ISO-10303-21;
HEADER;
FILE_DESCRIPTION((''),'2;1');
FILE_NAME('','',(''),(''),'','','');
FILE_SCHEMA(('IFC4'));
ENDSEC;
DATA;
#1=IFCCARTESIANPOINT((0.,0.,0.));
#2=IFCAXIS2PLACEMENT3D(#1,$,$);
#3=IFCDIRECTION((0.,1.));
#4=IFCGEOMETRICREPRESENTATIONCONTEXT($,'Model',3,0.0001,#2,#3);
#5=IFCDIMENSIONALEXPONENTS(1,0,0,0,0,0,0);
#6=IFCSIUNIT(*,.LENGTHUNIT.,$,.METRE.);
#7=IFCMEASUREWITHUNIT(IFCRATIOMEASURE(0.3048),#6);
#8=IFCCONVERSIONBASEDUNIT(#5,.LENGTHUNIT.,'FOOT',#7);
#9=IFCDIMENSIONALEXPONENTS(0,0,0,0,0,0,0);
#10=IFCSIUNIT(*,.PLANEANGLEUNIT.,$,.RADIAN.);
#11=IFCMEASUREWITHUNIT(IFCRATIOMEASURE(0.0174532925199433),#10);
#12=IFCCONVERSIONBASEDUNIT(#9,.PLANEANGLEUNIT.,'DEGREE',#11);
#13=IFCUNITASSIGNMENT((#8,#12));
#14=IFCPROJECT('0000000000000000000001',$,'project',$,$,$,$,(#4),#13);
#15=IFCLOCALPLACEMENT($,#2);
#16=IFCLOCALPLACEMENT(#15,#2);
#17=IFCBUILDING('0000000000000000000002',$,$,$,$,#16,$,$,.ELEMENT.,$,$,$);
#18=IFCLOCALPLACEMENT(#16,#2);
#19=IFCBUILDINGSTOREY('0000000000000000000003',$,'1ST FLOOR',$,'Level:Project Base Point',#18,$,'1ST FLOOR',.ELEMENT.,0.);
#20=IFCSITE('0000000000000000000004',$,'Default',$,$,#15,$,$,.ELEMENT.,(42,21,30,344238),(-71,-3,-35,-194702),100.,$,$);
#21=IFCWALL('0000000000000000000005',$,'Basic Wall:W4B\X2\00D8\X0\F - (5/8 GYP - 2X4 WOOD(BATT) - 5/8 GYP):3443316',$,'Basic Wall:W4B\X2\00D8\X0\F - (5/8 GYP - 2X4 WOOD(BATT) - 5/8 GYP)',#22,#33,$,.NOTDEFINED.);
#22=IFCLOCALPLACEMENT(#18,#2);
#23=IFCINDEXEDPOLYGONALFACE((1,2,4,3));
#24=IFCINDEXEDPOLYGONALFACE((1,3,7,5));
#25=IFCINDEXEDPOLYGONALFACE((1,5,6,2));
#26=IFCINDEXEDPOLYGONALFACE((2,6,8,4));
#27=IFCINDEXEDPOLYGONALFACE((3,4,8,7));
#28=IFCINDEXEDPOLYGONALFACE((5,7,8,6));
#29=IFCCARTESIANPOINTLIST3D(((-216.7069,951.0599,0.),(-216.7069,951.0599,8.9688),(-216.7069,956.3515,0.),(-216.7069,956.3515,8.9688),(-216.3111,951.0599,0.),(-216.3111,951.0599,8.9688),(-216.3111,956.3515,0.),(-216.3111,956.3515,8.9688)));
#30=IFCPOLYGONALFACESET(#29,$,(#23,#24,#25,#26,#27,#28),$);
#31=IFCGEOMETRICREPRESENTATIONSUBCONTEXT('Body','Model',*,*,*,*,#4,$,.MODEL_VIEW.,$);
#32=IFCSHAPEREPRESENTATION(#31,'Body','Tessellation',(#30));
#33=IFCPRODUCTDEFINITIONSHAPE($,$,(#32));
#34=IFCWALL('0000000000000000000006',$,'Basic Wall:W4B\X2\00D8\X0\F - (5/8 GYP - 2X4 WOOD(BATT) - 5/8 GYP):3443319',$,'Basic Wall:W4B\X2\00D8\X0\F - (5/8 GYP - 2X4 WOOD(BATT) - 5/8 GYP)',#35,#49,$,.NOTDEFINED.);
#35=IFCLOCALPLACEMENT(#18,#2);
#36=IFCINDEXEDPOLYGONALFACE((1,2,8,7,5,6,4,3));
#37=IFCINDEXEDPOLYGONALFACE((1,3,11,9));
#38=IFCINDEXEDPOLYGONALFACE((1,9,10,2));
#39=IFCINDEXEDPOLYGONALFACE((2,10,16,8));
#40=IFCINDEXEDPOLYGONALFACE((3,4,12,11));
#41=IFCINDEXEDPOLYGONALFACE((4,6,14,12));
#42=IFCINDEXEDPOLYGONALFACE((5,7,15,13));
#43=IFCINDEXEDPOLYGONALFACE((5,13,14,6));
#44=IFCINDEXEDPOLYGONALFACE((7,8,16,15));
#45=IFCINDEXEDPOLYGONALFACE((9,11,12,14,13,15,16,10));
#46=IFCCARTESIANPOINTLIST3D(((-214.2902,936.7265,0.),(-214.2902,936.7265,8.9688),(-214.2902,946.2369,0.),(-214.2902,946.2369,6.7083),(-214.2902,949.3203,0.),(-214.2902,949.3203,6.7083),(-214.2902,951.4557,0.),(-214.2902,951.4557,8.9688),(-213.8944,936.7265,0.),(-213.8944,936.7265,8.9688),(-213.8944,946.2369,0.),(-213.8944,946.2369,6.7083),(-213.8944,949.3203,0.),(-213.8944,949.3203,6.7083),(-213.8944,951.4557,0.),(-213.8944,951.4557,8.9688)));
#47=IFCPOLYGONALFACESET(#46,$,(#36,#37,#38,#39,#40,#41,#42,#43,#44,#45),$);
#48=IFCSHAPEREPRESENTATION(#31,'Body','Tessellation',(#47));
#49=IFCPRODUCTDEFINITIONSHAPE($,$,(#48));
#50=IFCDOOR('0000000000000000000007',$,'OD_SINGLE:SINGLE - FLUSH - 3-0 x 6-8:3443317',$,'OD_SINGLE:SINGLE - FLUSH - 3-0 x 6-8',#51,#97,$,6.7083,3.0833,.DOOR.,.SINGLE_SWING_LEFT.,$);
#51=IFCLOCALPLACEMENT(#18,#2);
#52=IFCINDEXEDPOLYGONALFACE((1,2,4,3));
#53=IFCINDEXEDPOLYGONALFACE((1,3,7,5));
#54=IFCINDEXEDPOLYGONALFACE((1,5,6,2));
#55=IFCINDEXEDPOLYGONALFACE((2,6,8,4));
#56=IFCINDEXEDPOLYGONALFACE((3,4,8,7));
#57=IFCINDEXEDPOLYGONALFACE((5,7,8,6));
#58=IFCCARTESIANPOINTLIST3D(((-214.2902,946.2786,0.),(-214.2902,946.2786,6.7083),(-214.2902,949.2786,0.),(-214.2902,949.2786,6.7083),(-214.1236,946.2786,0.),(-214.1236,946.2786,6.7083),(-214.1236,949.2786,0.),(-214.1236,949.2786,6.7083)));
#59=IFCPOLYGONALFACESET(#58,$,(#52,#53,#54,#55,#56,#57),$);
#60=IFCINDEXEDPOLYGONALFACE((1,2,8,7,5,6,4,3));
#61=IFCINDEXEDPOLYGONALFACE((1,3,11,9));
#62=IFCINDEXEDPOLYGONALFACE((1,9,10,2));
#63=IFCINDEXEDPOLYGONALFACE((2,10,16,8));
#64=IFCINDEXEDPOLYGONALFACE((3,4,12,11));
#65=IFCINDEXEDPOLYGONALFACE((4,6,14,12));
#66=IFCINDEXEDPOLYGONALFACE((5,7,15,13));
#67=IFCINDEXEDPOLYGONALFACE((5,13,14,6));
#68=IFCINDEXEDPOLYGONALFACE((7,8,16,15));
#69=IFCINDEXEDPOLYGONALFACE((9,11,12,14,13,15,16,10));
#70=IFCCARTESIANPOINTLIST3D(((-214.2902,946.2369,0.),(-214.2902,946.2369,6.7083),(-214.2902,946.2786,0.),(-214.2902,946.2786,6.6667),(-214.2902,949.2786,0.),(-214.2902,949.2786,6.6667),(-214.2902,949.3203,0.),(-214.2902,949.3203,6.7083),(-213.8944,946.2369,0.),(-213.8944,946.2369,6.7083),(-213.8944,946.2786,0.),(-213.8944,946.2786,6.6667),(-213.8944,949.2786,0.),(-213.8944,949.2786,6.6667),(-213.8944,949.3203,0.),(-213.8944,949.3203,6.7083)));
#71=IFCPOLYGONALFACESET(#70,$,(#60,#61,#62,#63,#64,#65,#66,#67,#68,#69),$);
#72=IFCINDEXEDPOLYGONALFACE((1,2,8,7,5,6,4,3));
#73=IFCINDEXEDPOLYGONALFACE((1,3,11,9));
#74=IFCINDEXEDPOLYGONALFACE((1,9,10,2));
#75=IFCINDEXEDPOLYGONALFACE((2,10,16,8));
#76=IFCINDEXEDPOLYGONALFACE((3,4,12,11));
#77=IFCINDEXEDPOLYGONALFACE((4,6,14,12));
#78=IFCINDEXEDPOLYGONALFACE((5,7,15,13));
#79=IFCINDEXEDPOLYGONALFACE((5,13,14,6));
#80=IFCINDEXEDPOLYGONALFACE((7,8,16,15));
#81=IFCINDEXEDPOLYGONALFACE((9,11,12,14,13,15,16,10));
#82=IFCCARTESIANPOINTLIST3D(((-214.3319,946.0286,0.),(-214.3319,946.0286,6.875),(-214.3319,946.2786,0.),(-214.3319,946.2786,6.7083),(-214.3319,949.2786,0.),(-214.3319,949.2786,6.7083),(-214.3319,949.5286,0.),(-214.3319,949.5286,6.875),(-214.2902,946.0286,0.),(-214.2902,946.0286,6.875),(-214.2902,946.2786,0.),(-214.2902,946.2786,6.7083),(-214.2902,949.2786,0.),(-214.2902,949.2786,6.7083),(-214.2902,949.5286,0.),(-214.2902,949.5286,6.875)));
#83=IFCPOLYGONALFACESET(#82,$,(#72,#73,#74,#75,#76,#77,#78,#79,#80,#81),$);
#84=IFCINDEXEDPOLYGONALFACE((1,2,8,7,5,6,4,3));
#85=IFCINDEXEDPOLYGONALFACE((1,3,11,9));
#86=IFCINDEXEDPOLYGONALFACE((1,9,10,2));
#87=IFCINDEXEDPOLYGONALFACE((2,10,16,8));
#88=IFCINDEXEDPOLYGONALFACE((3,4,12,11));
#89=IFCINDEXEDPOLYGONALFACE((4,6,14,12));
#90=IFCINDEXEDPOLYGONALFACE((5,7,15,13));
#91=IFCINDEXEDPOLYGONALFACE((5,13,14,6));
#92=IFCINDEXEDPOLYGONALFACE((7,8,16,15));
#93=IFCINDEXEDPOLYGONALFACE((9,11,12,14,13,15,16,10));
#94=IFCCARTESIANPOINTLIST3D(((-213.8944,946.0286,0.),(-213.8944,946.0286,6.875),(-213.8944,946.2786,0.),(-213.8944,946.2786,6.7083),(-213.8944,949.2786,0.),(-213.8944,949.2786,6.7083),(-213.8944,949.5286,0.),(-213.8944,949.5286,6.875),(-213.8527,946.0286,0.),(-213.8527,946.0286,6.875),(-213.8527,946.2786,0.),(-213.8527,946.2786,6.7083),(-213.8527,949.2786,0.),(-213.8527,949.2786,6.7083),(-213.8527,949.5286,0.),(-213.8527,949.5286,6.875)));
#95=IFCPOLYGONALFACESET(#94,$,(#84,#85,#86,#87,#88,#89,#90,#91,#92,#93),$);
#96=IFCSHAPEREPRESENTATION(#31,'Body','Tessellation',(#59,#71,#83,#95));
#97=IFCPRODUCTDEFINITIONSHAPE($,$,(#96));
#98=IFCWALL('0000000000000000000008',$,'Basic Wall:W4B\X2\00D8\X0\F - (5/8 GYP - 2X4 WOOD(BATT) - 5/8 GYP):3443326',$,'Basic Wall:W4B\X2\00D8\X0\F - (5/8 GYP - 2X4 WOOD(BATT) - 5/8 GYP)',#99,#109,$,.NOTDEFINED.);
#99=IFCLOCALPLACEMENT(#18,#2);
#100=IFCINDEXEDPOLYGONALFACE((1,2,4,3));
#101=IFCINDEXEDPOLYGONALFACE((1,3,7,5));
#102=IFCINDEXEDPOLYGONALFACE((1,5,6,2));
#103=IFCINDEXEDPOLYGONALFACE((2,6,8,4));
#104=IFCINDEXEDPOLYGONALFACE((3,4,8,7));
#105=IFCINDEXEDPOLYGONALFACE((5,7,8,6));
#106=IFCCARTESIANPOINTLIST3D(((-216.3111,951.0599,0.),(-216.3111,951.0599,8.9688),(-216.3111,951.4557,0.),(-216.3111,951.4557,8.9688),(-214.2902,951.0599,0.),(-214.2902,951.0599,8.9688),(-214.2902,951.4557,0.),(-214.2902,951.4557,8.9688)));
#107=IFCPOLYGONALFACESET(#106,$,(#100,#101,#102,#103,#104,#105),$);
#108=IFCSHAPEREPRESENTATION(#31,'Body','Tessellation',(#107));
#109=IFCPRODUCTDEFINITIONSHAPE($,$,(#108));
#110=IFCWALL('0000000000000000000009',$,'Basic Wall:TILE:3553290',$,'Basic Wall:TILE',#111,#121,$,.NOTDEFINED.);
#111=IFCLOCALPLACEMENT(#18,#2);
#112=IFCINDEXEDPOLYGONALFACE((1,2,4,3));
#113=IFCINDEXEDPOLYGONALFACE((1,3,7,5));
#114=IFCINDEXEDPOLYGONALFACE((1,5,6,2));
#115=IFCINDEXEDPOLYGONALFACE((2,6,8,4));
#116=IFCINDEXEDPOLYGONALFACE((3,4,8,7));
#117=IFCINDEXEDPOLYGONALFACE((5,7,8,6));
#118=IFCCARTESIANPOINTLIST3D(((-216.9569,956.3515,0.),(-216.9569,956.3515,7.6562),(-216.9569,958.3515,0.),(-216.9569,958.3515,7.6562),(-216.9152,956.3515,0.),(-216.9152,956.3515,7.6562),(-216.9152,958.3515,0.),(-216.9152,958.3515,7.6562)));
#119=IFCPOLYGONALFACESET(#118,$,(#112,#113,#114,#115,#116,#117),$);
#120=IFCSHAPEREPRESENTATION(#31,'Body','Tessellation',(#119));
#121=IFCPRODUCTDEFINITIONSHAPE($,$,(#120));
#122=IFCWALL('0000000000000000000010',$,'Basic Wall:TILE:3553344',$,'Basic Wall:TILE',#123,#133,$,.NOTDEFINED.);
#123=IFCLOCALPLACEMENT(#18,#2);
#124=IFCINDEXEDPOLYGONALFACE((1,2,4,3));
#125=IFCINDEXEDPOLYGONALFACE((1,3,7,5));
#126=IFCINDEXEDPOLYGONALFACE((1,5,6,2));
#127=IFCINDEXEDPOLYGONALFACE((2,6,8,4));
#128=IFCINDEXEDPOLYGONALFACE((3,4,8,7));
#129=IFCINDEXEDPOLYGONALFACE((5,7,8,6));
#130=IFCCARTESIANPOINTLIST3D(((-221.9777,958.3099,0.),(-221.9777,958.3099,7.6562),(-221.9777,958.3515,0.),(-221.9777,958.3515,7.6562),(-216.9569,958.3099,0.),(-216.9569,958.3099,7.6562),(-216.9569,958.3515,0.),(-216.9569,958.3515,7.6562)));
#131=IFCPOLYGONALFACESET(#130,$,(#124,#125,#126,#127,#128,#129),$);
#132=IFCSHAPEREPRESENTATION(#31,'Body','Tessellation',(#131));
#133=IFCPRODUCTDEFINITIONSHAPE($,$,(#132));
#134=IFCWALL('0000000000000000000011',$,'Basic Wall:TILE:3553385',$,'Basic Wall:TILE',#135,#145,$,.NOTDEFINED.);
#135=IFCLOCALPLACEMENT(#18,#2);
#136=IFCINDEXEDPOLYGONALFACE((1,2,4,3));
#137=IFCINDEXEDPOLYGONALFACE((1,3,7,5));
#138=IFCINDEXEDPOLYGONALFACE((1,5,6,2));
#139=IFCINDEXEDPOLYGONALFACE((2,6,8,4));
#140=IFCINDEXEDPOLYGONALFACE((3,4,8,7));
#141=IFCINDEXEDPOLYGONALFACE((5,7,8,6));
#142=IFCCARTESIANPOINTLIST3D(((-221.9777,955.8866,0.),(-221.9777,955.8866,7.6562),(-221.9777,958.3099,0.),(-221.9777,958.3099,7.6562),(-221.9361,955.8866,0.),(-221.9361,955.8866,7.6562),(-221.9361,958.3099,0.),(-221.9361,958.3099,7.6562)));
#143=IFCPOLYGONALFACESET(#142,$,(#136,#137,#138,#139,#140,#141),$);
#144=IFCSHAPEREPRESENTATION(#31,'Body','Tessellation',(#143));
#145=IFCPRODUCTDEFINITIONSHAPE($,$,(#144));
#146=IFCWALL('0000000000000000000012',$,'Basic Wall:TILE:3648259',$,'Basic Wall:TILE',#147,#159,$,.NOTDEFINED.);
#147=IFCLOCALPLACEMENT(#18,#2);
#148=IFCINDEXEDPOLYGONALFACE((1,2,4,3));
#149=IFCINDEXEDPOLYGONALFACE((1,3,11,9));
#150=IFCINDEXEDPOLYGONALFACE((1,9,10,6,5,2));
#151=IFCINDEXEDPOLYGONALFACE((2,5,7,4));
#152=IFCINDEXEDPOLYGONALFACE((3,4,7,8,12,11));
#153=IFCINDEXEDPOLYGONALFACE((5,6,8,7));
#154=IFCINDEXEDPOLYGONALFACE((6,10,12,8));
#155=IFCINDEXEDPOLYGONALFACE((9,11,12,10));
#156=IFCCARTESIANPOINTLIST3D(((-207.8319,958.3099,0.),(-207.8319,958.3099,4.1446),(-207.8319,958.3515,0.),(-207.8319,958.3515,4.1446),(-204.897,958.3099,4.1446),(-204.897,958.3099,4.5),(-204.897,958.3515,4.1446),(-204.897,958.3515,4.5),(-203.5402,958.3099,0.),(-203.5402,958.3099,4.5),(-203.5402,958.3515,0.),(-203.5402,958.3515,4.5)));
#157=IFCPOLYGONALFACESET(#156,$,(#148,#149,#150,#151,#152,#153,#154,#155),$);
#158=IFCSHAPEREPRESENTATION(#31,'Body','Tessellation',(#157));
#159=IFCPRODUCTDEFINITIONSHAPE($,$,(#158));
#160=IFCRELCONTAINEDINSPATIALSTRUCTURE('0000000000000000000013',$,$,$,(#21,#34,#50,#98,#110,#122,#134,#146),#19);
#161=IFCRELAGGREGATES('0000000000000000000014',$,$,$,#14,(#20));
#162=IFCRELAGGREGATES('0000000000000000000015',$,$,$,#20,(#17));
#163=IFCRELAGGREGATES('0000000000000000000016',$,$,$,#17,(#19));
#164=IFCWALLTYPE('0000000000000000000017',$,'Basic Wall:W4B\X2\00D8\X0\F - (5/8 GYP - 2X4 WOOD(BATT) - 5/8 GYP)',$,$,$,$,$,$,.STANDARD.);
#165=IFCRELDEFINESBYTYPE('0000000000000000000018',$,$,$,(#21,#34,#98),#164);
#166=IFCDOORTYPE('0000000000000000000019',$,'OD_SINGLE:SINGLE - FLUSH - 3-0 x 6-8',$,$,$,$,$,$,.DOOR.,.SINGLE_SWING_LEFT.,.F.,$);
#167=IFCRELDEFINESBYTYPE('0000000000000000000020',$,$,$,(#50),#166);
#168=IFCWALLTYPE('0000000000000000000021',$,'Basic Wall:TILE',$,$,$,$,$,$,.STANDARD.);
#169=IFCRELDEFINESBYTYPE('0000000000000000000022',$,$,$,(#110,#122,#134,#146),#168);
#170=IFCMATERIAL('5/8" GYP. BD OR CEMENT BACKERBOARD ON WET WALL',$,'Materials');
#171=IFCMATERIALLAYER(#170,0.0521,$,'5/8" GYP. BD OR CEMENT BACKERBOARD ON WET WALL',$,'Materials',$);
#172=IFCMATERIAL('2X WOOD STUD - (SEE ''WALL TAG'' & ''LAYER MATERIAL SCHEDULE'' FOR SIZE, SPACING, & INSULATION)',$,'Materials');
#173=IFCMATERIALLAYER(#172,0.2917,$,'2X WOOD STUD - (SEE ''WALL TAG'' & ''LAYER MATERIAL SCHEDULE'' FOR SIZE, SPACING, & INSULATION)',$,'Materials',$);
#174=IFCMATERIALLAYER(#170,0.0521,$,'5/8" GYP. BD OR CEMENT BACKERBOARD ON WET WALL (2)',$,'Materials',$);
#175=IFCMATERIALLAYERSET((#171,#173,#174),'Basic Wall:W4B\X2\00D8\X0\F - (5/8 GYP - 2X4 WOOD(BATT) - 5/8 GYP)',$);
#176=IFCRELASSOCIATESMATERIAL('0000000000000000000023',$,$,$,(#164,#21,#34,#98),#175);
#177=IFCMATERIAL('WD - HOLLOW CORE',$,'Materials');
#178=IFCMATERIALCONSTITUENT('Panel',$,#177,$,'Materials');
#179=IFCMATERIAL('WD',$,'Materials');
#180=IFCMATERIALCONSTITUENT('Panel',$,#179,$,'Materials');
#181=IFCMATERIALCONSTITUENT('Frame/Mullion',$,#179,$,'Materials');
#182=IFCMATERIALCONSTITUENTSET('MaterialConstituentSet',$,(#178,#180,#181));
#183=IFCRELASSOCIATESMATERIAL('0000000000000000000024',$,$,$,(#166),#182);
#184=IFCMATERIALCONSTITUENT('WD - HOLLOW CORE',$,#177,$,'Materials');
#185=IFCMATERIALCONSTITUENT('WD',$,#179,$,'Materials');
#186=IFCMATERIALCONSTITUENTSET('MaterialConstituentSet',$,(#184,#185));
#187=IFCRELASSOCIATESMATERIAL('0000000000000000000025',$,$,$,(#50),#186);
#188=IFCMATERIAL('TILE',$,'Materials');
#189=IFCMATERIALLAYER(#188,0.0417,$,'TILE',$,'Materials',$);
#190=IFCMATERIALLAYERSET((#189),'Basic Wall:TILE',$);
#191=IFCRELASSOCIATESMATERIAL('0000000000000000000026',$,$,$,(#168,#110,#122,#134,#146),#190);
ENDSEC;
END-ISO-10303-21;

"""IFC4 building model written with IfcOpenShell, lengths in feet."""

from ifc_helpers import new_model, entity, si_unit, converted_unit, direction, frame, frame_2d, origin, origin_2d_with_axis, place, context, subcontext, project, spatial, polyline, rectangle, outline, extrude, source, transform, mapped, material, layer, layer_set, layer_usage, constituent, constituent_set, type_object, type_shapes, element, fill, save


model = new_model("IFC4")

# Units and contexts
model_context = context("Model", 3, precision=0.0001, world=origin(), true_north=direction((0.0, 1.0)))
body_context = subcontext(model_context, "Body", "Model", "MODEL_VIEW")
ifc_project = project(units=[converted_unit("LENGTHUNIT", "FOOT", entity("IfcRatioMeasure", 0.3048), si_unit("LENGTHUNIT", "METRE"), dimensions=[1, 0, 0, 0, 0, 0, 0]), converted_unit("PLANEANGLEUNIT", "DEGREE", entity("IfcRatioMeasure", 0.0174532925199433), si_unit("PLANEANGLEUNIT", "RADIAN"), dimensions=[0, 0, 0, 0, 0, 0, 0])], contexts=[model_context])

# Site, building, storey
site_placement = place(None, origin())
site = spatial("IfcSite", under=ifc_project, at=site_placement, Name="Default", CompositionType="ELEMENT", RefLatitude=(42, 21, 30, 344238), RefLongitude=(-71, -3, -35, -194702), RefElevation=100.0)
building_placement = place(site_placement, origin())
building = spatial("IfcBuilding", under=site, at=building_placement, CompositionType="ELEMENT")
storey_placement = place(building_placement, origin())
storey = spatial("IfcBuildingStorey", under=building, at=storey_placement, Name="1ST FLOOR", ObjectType="Level:Project Base Point", LongName="1ST FLOOR", CompositionType="ELEMENT", Elevation=0.0)

# Shared definitions
ifc_material_1 = material(Name="5/8\" GYP. BD OR CEMENT BACKERBOARD ON WET WALL", Category="Materials")
ifc_layer_1 = layer(ifc_material_1, 0.0521, Name="5/8\" GYP. BD OR CEMENT BACKERBOARD ON WET WALL", Category="Materials")
ifc_material_2 = material(Name="2X WOOD STUD - (SEE 'WALL TAG' & 'LAYER MATERIAL SCHEDULE' FOR SIZE, SPACING, & INSULATION)", Category="Materials")
ifc_layer_2 = layer(ifc_material_2, 0.2917, Name="2X WOOD STUD - (SEE 'WALL TAG' & 'LAYER MATERIAL SCHEDULE' FOR SIZE, SPACING, & INSULATION)", Category="Materials")
ifc_layer_3 = layer(ifc_material_1, 0.0521, Name="5/8\" GYP. BD OR CEMENT BACKERBOARD ON WET WALL (2)", Category="Materials")
ifc_layer_set_1 = layer_set([ifc_layer_1, ifc_layer_2, ifc_layer_3], Name="Basic Wall:W4BØF - (5/8 GYP - 2X4 WOOD(BATT) - 5/8 GYP)")
wall_type_1 = type_object("IfcWallType", Name="Basic Wall:W4BØF - (5/8 GYP - 2X4 WOOD(BATT) - 5/8 GYP)", PredefinedType="STANDARD", material=ifc_layer_set_1)
ifc_material_3 = material(Name="WD - HOLLOW CORE", Category="Materials")
ifc_material_4 = material(Name="WD", Category="Materials")

# Wall
ifc_layer_usage_1 = layer_usage(ifc_layer_set_1, "AXIS2", "POSITIVE", -0.1979)
wall_1_placement = place(storey_placement, frame((-216.509, 951.0599, 0.0), z_axis=(0.0, 0.0, 1.0), x_axis=(0.0, 1.0, 0.0)))
element("IfcWall", 1, at=wall_1_placement, inside=storey, type_object=wall_type_1, material=ifc_layer_usage_1, Name="Basic Wall:W4BØF - (5/8 GYP - 2X4 WOOD(BATT) - 5/8 GYP):3443316", ObjectType="Basic Wall:W4BØF - (5/8 GYP - 2X4 WOOD(BATT) - 5/8 GYP)", PredefinedType="NOTDEFINED", context=body_context, shape_type="SweptSolid", body=[
    extrude(rectangle(XDim=5.2917, YDim=0.3958, at=frame_2d((2.6458, 0.0), x_axis=(-1.0, 0.0))), origin(), (0.0, 0.0, 1.0), 8.9688),
])

# Wall, opening, door
ifc_layer_usage_2 = layer_usage(ifc_layer_set_1, "AXIS2", "POSITIVE", -0.1979)
wall_2_placement = place(storey_placement, frame((-214.0923, 936.7265, 0.0), z_axis=(0.0, 0.0, 1.0), x_axis=(0.0, 1.0, 0.0)))
wall_2 = element("IfcWall", 2, at=wall_2_placement, inside=storey, type_object=wall_type_1, material=ifc_layer_usage_2, Name="Basic Wall:W4BØF - (5/8 GYP - 2X4 WOOD(BATT) - 5/8 GYP):3443319", ObjectType="Basic Wall:W4BØF - (5/8 GYP - 2X4 WOOD(BATT) - 5/8 GYP)", PredefinedType="NOTDEFINED", context=body_context, shape_type="SweptSolid", body=[
    extrude(rectangle(XDim=14.7292, YDim=0.3958, at=frame_2d((7.3646, 0.0), x_axis=(-1.0, 0.0))), origin(), (0.0, 0.0, 1.0), 8.9688),
])
opening_1_placement = place(wall_2_placement, frame((9.5104, -0.1979, 0.0)))
opening_1 = element("IfcOpeningElement", 3, at=opening_1_placement, cuts=wall_2, PredefinedType="OPENING", context=body_context, shape_type="SweptSolid", body=[
    extrude(rectangle(XDim=3.0833, YDim=6.7083, at=frame_2d((3.3542, 1.5417), x_axis=(0.0, -1.0))), frame((0.0, 0.0, 0.0), z_axis=(0.0, 1.0, 0.0), x_axis=(0.0, 0.0, 1.0)), (0.0, 0.0, 1.0), 0.3958),
])
ifc_constituent_1 = constituent(ifc_material_3, Name="WD - HOLLOW CORE", Category="Materials")
ifc_constituent_2 = constituent(ifc_material_4, Name="WD", Category="Materials")
ifc_constituent_set_1 = constituent_set(constituents=[ifc_constituent_1, ifc_constituent_2], Name="MaterialConstituentSet")
ifc_constituent_3 = constituent(ifc_material_3, Name="Panel", Category="Materials")
ifc_constituent_4 = constituent(ifc_material_4, Name="Panel", Category="Materials")
ifc_constituent_5 = constituent(ifc_material_4, Name="Frame/Mullion", Category="Materials")
ifc_constituent_set_2 = constituent_set(constituents=[ifc_constituent_3, ifc_constituent_4, ifc_constituent_5], Name="MaterialConstituentSet")
door_type_1 = type_object("IfcDoorType", Name="OD_SINGLE:SINGLE - FLUSH - 3-0 x 6-8", OperationType="SINGLE_SWING_LEFT", ParameterTakesPrecedence=False, PredefinedType="DOOR", material=ifc_constituent_set_2)
shared_shape_1 = source(origin(), body_context, "Body", "SweptSolid", [
    extrude(rectangle(XDim=3.0, YDim=0.1667, at=origin_2d_with_axis()), frame((1.5417, 0.3125, 0.0)), (0.0, 0.0, 1.0), 6.7083),
    extrude(outline(polyline([(-3.3646, -1.5417), (3.3438, -1.5417), (3.3438, -1.5), (-3.3229, -1.5), (-3.3229, 1.5), (3.3438, 1.5), (3.3438, 1.5417), (-3.3646, 1.5417), (-3.3646, -1.5417)])), frame((1.5417, 0.3958, 3.3438), z_axis=(0.0, -1.0, 0.0), x_axis=(0.0, 0.0, -1.0)), (0.0, 0.0, 1.0), 0.3958),
    extrude(outline(polyline([(-1.75, -3.4792), (1.75, -3.4792), (1.75, 3.3958), (1.5, 3.3958), (1.5, -3.3125), (-1.5, -3.3125), (-1.5, 3.3958), (-1.75, 3.3958), (-1.75, -3.4792)])), frame((1.5417, 0.4375, 3.3958), z_axis=(0.0, -1.0, 0.0), x_axis=(-1.0, 0.0, 0.0)), (0.0, 0.0, 1.0), 0.0417),
    extrude(outline(polyline([(-3.4792, -1.75), (3.3958, -1.75), (3.3958, -1.5), (-3.3125, -1.5), (-3.3125, 1.5), (3.3958, 1.5), (3.3958, 1.75), (-3.4792, 1.75), (-3.4792, -1.75)])), frame((1.5417, 0.0, 3.3958), z_axis=(0.0, -1.0, 0.0), x_axis=(0.0, 0.0, -1.0)), (0.0, 0.0, 1.0), 0.0417),
])
type_shapes(door_type_1, [shared_shape_1])
door_1_placement = place(opening_1_placement, origin())
door_1 = element("IfcDoor", 4, at=door_1_placement, inside=storey, type_object=door_type_1, material=ifc_constituent_set_1, Name="OD_SINGLE:SINGLE - FLUSH - 3-0 x 6-8:3443317", ObjectType="OD_SINGLE:SINGLE - FLUSH - 3-0 x 6-8", OperationType="SINGLE_SWING_LEFT", OverallHeight=6.7083, OverallWidth=3.0833, PredefinedType="DOOR", context=body_context, shape_type="MappedRepresentation", body=[
    mapped(shared_shape_1, transform((0.0, 0.0, 0.0), scale=1.0)),
])
fill(opening_1, door_1)

# Wall
ifc_layer_usage_3 = layer_usage(ifc_layer_set_1, "AXIS2", "NEGATIVE", 0.1979)
wall_3_placement = place(storey_placement, frame((-216.3111, 951.2578, 0.0)))
element("IfcWall", 5, at=wall_3_placement, inside=storey, type_object=wall_type_1, material=ifc_layer_usage_3, Name="Basic Wall:W4BØF - (5/8 GYP - 2X4 WOOD(BATT) - 5/8 GYP):3443326", ObjectType="Basic Wall:W4BØF - (5/8 GYP - 2X4 WOOD(BATT) - 5/8 GYP)", PredefinedType="NOTDEFINED", context=body_context, shape_type="SweptSolid", body=[
    extrude(rectangle(XDim=2.0208, YDim=0.3958, at=frame_2d((1.0104, 0.0), x_axis=(-1.0, 0.0))), origin(), (0.0, 0.0, 1.0), 8.9688),
])

# Shared definitions
ifc_material_5 = material(Name="TILE", Category="Materials")
ifc_layer_4 = layer(ifc_material_5, 0.0417, Name="TILE", Category="Materials")
ifc_layer_set_2 = layer_set([ifc_layer_4], Name="Basic Wall:TILE")
wall_type_2 = type_object("IfcWallType", Name="Basic Wall:TILE", PredefinedType="STANDARD", material=ifc_layer_set_2)

# Walls
ifc_layer_usage_4 = layer_usage(ifc_layer_set_2, "AXIS2", "NEGATIVE", 0.0208)
wall_4_placement = place(storey_placement, frame((-216.9361, 956.3515, 0.0), z_axis=(0.0, 0.0, 1.0), x_axis=(0.0, 1.0, 0.0)))
element("IfcWall", 6, at=wall_4_placement, inside=storey, type_object=wall_type_2, material=ifc_layer_usage_4, Name="Basic Wall:TILE:3553290", ObjectType="Basic Wall:TILE", PredefinedType="NOTDEFINED", context=body_context, shape_type="SweptSolid", body=[
    extrude(rectangle(XDim=2.0, YDim=0.0417, at=frame_2d((1.0, 0.0), x_axis=(-1.0, 0.0))), origin(), (0.0, 0.0, 1.0), 7.6562),
])
ifc_layer_usage_5 = layer_usage(ifc_layer_set_2, "AXIS2", "NEGATIVE", 0.0208)
wall_5_placement = place(storey_placement, frame((-216.9569, 958.3307, 0.0), z_axis=(0.0, 0.0, 1.0), x_axis=(-1.0, 0.0, 0.0)))
element("IfcWall", 7, at=wall_5_placement, inside=storey, type_object=wall_type_2, material=ifc_layer_usage_5, Name="Basic Wall:TILE:3553344", ObjectType="Basic Wall:TILE", PredefinedType="NOTDEFINED", context=body_context, shape_type="SweptSolid", body=[
    extrude(rectangle(XDim=5.0208, YDim=0.0417, at=frame_2d((2.5104, 0.0), x_axis=(-1.0, 0.0))), origin(), (0.0, 0.0, 1.0), 7.6562),
])
ifc_layer_usage_6 = layer_usage(ifc_layer_set_2, "AXIS2", "NEGATIVE", 0.0208)
wall_6_placement = place(storey_placement, frame((-221.9569, 958.3099, 0.0), z_axis=(0.0, 0.0, 1.0), x_axis=(0.0, -1.0, 0.0)))
element("IfcWall", 8, at=wall_6_placement, inside=storey, type_object=wall_type_2, material=ifc_layer_usage_6, Name="Basic Wall:TILE:3553385", ObjectType="Basic Wall:TILE", PredefinedType="NOTDEFINED", context=body_context, shape_type="SweptSolid", body=[
    extrude(rectangle(XDim=2.4233, YDim=0.0417, at=frame_2d((1.2116, 0.0), x_axis=(-1.0, 0.0))), origin(), (0.0, 0.0, 1.0), 7.6562),
])

# Wall, opening
ifc_layer_usage_7 = layer_usage(ifc_layer_set_2, "AXIS2", "NEGATIVE", 0.0208)
wall_7_placement = place(storey_placement, frame((-207.8319, 958.3307, 0.0)))
wall_7 = element("IfcWall", 9, at=wall_7_placement, inside=storey, type_object=wall_type_2, material=ifc_layer_usage_7, Name="Basic Wall:TILE:3648259", ObjectType="Basic Wall:TILE", PredefinedType="NOTDEFINED", context=body_context, shape_type="SweptSolid", body=[
    extrude(rectangle(XDim=4.2917, YDim=0.0417, at=frame_2d((2.1458, 0.0), x_axis=(-1.0, 0.0))), origin(), (0.0, 0.0, 1.0), 4.5),
])
opening_2_placement = place(wall_7_placement, origin())
element("IfcOpeningElement", 10, at=opening_2_placement, cuts=wall_7, PredefinedType="OPENING", context=body_context, shape_type="SweptSolid", body=[
    extrude(rectangle(XDim=0.3554, YDim=2.9349, at=frame_2d((0.0, 0.0), x_axis=(0.0, 1.0))), frame((1.4674, 0.0208, 4.3223), z_axis=(0.0, -1.0, 0.0), x_axis=(-1.0, 0.0, 0.0)), (0.0, 0.0, 1.0), 0.0417),
])

save(model, "model.ifc")
